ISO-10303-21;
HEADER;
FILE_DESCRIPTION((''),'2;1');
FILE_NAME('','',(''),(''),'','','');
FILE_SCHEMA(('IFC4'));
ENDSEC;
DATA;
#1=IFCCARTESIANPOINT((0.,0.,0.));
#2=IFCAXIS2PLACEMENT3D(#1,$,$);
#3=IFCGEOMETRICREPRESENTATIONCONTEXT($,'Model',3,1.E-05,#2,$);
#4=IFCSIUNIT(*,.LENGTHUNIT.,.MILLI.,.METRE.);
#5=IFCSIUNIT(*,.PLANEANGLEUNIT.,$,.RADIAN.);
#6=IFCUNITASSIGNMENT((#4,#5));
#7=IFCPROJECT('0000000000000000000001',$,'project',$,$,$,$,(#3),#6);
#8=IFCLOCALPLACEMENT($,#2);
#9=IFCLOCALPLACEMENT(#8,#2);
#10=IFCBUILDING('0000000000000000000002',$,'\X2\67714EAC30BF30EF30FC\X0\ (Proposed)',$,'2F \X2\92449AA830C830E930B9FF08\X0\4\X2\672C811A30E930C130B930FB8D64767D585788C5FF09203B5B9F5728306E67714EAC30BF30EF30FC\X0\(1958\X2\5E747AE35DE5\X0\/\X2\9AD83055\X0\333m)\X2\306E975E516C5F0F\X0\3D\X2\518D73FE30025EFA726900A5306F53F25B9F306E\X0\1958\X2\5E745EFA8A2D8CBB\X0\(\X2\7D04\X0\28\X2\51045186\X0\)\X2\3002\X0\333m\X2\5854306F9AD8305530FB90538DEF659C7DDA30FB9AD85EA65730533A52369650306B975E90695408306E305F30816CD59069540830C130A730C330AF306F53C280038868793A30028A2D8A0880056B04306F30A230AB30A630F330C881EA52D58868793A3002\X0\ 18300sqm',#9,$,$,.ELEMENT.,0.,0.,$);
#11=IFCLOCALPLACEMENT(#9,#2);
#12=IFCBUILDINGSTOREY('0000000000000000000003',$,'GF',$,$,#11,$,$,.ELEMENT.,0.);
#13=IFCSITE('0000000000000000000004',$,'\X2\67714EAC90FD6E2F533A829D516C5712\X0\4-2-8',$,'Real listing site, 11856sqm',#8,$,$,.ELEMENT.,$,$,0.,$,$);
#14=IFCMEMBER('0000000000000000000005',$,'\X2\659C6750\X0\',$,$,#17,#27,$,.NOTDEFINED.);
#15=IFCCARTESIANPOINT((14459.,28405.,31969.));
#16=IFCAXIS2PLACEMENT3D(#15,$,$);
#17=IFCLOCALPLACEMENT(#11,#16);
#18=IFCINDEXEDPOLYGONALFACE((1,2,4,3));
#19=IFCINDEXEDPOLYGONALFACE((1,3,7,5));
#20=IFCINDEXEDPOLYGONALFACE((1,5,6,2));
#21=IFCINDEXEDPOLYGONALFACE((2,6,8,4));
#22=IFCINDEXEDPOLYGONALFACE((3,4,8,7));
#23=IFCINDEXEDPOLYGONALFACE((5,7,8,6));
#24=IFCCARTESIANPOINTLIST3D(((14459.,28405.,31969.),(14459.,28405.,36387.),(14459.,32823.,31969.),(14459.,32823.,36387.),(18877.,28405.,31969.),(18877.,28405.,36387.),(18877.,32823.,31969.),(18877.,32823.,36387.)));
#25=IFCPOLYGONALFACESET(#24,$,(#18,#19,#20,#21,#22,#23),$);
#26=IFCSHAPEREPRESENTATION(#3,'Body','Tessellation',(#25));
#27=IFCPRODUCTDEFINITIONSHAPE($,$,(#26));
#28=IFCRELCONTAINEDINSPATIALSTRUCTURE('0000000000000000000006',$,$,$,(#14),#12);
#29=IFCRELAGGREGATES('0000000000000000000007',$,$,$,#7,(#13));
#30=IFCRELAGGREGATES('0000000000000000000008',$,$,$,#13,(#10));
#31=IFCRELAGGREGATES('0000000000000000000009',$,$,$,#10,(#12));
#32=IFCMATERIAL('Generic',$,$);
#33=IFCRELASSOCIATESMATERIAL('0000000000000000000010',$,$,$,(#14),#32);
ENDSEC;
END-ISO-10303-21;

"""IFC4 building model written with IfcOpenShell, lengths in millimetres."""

from ifc_helpers import new_model, si_unit, frame, frame_2d, origin, place, context, project, spatial, rectangle, extrude, material, element, save


model = new_model("IFC4")

# Units and contexts
model_context = context("Model", 3, precision=1e-05, world=origin())
ifc_project = project(units=[si_unit("LENGTHUNIT", "METRE", prefix="MILLI"), si_unit("PLANEANGLEUNIT", "RADIAN")], contexts=[model_context])

# Site, building, storey
site_placement = place(None, origin())
site = spatial("IfcSite", under=ifc_project, at=site_placement, Name="東京都港区芝公園4-2-8", ObjectType="Real listing site, 11856sqm", CompositionType="ELEMENT", RefElevation=0.0)
building_placement = place(site_placement, origin())
building = spatial("IfcBuilding", under=site, at=building_placement, Name="東京タワー (Proposed)", ObjectType="2F 鉄骨トラス（4本脚ラチス・赤白塗装）※実在の東京タワー(1958年竣工/高さ333m)の非公式3D再現。建物¥は史実の1958年建設費(約28億円)。333m塔は高さ・道路斜線・高度地区制限に非適合のため法適合チェックは参考表示。設計者欄はアカウント自動表示。 18300sqm", CompositionType="ELEMENT", ElevationOfRefHeight=0.0, ElevationOfTerrain=0.0)
storey_placement = place(building_placement, origin())
storey = spatial("IfcBuildingStorey", under=building, at=storey_placement, Name="GF", CompositionType="ELEMENT", Elevation=0.0)

# Shared definitions
ifc_material = material(Name="Generic")

# Member
member_1_placement = place(storey_placement, frame((14459.0, 28405.0, 31969.0)))
element("IfcMember", 1, at=member_1_placement, inside=storey, material=ifc_material, Name="斜材", PredefinedType="NOTDEFINED", context=model_context, shape_type="SweptSolid", body=[
    extrude(rectangle(XDim=4418.0, YDim=4418.0, at=frame_2d((2209.0, 2209.0))), frame((14459.0, 28405.0, 31969.0)), (0.0, 0.0, 1.0), 4418.0),
])

save(model, "model.ifc")
